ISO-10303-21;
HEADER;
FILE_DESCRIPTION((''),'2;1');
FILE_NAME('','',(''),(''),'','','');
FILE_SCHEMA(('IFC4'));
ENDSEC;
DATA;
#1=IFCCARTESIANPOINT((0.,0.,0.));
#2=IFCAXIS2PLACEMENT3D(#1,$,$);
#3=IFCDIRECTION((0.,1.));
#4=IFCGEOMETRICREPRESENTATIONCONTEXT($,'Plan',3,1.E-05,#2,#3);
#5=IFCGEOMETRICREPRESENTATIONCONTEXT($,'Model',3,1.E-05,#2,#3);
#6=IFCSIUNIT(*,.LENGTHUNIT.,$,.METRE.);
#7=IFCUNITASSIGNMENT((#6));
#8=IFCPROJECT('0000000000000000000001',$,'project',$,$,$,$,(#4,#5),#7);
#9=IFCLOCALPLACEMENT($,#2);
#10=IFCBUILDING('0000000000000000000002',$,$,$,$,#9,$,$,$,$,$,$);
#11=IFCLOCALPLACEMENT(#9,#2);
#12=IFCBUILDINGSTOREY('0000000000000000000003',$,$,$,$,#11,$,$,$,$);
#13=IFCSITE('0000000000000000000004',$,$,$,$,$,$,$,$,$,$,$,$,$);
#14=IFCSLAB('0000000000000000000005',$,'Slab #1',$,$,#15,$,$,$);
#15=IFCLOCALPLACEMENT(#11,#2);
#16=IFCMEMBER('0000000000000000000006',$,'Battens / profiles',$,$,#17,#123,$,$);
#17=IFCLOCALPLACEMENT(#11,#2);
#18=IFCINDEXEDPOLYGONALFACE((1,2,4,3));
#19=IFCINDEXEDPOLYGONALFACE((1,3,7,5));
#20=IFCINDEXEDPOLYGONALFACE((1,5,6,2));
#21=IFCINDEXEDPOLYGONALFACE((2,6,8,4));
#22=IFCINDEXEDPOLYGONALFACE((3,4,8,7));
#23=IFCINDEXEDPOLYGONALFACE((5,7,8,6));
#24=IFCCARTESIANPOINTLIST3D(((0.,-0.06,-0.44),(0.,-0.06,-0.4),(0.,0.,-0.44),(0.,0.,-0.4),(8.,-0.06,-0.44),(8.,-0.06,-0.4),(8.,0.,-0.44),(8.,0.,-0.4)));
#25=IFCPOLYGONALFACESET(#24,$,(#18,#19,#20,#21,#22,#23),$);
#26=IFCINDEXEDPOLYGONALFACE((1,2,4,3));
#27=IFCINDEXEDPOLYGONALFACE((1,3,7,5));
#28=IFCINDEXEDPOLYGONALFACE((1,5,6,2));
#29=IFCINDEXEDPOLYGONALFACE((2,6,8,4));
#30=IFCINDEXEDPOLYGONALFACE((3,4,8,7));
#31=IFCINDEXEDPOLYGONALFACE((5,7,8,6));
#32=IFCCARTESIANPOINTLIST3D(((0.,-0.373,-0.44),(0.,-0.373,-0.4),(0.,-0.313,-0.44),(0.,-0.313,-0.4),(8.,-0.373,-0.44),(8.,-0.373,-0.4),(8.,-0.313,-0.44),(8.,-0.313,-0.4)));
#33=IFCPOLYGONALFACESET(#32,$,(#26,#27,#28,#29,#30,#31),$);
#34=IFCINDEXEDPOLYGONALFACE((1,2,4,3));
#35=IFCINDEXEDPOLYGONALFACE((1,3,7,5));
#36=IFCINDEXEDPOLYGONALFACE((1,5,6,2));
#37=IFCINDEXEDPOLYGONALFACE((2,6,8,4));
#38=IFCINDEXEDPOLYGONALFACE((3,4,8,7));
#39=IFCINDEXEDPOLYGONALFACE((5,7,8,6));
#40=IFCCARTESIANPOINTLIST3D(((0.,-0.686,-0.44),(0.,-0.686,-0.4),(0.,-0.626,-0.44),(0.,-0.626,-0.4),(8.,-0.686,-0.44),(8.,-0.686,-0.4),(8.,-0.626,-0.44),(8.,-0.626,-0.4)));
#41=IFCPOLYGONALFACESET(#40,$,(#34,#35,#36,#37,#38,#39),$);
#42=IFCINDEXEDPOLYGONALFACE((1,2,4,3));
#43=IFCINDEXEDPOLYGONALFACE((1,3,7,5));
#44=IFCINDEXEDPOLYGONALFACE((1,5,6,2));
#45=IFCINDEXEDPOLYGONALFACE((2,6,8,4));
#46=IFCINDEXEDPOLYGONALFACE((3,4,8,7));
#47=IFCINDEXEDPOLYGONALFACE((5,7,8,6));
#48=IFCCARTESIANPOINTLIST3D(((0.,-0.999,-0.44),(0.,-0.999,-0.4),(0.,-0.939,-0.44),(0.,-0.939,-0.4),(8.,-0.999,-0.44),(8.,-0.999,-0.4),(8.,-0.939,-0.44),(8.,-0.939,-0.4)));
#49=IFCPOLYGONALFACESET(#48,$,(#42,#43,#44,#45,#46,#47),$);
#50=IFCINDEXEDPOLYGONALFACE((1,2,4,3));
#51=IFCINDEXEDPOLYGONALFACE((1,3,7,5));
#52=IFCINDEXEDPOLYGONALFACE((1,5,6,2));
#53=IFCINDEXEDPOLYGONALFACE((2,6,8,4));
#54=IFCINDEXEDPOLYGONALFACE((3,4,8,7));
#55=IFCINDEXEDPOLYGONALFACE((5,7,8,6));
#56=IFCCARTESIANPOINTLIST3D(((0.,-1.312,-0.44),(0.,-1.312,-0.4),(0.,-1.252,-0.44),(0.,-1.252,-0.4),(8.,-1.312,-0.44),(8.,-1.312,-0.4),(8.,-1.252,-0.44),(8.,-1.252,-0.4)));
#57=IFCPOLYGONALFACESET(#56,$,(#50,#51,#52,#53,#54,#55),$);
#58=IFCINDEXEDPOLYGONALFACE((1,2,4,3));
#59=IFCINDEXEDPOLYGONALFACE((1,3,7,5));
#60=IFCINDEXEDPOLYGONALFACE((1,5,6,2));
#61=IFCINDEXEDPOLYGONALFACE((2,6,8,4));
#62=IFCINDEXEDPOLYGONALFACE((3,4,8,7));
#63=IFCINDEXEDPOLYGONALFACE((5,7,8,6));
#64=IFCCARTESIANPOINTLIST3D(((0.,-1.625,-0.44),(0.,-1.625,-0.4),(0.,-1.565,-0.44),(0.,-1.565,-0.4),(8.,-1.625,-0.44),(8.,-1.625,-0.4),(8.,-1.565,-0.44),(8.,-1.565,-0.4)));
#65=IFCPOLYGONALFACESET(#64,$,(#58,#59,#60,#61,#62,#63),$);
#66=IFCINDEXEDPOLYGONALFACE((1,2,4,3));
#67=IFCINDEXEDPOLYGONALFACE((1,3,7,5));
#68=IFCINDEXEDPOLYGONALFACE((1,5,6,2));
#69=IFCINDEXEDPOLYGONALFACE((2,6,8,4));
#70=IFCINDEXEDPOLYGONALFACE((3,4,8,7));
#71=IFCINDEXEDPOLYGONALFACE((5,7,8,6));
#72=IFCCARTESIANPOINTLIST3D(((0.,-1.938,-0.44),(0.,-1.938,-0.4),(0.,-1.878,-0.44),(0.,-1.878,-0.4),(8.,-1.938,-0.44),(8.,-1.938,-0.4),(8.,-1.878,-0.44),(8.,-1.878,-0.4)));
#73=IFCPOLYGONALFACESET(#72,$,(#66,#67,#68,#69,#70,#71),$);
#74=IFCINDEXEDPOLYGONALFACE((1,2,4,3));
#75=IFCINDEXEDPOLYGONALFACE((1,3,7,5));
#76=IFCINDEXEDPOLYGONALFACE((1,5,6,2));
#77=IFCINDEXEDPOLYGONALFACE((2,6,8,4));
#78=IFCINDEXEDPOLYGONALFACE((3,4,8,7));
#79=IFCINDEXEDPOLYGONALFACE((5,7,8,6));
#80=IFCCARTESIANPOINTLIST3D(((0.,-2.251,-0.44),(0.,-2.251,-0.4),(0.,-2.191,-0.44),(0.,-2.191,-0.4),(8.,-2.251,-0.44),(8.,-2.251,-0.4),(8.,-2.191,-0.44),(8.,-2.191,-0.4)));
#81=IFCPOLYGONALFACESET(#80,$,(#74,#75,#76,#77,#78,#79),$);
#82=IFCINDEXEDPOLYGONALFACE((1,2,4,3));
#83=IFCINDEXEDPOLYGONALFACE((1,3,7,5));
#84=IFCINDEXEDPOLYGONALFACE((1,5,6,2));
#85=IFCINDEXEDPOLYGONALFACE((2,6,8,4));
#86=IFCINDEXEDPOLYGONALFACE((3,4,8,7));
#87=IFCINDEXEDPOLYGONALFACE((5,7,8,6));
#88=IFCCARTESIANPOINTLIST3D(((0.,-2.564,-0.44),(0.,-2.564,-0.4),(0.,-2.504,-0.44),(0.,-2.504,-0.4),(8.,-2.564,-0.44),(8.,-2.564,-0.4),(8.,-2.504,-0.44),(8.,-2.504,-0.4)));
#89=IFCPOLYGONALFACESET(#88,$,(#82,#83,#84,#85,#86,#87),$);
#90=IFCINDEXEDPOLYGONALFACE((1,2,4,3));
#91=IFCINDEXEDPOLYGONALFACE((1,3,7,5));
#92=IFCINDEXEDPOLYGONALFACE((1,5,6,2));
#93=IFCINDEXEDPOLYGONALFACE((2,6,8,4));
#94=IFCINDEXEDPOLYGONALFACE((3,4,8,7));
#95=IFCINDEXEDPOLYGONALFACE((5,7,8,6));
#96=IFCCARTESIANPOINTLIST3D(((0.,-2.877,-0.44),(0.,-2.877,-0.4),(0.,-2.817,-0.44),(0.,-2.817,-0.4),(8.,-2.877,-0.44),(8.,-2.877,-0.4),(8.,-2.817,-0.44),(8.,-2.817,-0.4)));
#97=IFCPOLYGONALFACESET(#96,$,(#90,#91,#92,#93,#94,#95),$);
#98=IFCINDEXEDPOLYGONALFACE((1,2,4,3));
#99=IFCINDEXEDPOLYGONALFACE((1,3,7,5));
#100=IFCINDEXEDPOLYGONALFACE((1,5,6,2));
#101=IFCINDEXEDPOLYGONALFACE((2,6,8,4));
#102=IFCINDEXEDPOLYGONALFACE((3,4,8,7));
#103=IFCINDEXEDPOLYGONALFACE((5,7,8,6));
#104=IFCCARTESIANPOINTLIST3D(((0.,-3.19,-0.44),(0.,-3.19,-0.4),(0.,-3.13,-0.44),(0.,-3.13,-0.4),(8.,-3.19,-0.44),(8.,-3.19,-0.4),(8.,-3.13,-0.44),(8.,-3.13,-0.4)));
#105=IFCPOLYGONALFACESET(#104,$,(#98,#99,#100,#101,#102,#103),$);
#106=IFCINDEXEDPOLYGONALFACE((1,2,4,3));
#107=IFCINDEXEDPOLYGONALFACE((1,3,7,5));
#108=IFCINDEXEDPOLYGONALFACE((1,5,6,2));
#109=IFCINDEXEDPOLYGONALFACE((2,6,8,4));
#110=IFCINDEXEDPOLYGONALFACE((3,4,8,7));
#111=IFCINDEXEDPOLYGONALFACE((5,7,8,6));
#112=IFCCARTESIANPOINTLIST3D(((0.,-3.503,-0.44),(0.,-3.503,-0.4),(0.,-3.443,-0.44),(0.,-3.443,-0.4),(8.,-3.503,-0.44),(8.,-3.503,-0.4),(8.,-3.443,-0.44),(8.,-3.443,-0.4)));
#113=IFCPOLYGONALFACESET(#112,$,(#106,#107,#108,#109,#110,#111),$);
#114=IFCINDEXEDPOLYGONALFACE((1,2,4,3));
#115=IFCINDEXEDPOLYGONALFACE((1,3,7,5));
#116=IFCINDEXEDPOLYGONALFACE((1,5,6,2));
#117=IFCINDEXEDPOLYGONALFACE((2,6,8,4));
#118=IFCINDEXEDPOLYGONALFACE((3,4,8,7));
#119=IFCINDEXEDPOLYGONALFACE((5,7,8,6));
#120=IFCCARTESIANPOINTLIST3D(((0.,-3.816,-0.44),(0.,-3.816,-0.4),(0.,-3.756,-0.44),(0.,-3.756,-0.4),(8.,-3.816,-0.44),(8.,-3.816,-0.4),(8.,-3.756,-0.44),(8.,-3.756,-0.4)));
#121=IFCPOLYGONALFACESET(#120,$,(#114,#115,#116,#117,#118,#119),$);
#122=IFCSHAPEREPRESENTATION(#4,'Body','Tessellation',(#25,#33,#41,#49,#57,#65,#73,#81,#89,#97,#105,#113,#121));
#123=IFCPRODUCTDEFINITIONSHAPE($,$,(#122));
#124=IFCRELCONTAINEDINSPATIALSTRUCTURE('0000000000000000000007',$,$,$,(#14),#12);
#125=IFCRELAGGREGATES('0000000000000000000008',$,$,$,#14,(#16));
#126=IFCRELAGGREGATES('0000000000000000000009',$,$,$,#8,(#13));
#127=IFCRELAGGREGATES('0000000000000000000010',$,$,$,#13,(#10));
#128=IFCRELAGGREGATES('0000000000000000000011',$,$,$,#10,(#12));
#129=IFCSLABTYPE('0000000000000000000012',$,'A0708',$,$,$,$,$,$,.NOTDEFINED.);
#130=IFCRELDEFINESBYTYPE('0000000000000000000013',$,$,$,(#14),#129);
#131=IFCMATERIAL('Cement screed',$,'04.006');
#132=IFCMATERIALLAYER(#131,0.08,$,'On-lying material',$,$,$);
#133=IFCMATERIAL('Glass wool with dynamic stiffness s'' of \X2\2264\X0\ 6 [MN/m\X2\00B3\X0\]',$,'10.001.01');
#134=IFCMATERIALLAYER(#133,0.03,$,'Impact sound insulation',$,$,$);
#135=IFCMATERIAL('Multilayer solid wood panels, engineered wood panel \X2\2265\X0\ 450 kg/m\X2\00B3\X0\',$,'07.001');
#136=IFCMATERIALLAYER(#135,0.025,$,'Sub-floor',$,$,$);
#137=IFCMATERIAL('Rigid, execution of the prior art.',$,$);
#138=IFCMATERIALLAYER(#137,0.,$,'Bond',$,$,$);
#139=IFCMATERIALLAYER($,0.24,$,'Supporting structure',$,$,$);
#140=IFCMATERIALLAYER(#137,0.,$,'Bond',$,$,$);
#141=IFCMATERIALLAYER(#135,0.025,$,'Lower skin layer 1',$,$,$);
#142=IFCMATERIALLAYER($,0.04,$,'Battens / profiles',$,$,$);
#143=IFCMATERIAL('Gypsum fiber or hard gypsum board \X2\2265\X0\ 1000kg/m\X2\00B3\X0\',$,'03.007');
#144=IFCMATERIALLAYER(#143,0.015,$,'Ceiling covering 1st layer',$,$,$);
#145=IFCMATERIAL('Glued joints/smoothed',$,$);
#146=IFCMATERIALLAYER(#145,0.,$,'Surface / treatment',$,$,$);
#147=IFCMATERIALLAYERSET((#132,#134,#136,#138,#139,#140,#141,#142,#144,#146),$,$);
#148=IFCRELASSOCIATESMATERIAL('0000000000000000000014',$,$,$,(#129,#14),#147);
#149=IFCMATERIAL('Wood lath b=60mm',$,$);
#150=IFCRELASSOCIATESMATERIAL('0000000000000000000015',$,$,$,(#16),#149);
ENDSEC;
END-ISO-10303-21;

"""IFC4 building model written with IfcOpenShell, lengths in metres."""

from ifc_helpers import new_model, si_unit, direction, frame, frame_2d, origin, place, context, project, spatial, rectangle, extrude, material, layer, layer_set, type_object, element, aggregate, save


model = new_model("IFC4")

# Units and contexts
plan_context = context("Plan", 3, precision=1e-05, world=origin(), true_north=direction((0.0, 1.0)))
model_context = context("Model", 3, precision=1e-05, world=origin(), true_north=direction((0.0, 1.0)))
ifc_project = project(units=[si_unit("LENGTHUNIT", "METRE")], contexts=[plan_context, model_context])

# Site, building, storey
site = spatial("IfcSite", under=ifc_project)
building_placement = place(None, origin())
building = spatial("IfcBuilding", under=site, at=building_placement)
storey_placement = place(building_placement, origin())
storey = spatial("IfcBuildingStorey", under=building, at=storey_placement)

# Slab, member
ifc_material_1 = material(Name="Cement screed", Category="04.006")
ifc_layer_1 = layer(ifc_material_1, 0.08, Name="On-lying material")
ifc_material_2 = material(Name="Glass wool with dynamic stiffness s' of ≤ 6 [MN/m³]", Category="10.001.01")
ifc_layer_2 = layer(ifc_material_2, 0.03, Name="Impact sound insulation")
ifc_material_3 = material(Name="Multilayer solid wood panels, engineered wood panel ≥ 450 kg/m³", Category="07.001")
ifc_layer_3 = layer(ifc_material_3, 0.025, Name="Sub-floor")
ifc_material_4 = material(Name="Rigid, execution of the prior art.")
ifc_layer_4 = layer(ifc_material_4, 0.0, Name="Bond")
ifc_layer_5 = layer(None, 0.24, Name="Supporting structure")
ifc_layer_6 = layer(ifc_material_4, 0.0, Name="Bond")
ifc_layer_7 = layer(ifc_material_3, 0.025, Name="Lower skin layer 1")
ifc_layer_8 = layer(None, 0.04, Name="Battens / profiles")
ifc_material_5 = material(Name="Gypsum fiber or hard gypsum board ≥ 1000kg/m³", Category="03.007")
ifc_layer_9 = layer(ifc_material_5, 0.015, Name="Ceiling covering 1st layer")
ifc_material_6 = material(Name="Glued joints/smoothed")
ifc_layer_10 = layer(ifc_material_6, 0.0, Name="Surface / treatment")
ifc_layer_set = layer_set([ifc_layer_1, ifc_layer_2, ifc_layer_3, ifc_layer_4, ifc_layer_5, ifc_layer_6, ifc_layer_7, ifc_layer_8, ifc_layer_9, ifc_layer_10])
slab_type = type_object("IfcSlabType", Name="A0708", PredefinedType="NOTDEFINED", material=ifc_layer_set)
slab_placement = place(None, frame((0.0, 0.0, 0.0), z_axis=(0.0, 0.0, -1.0), x_axis=(1.0, 0.0, 0.0)))
slab = element("IfcSlab", 1, at=slab_placement, inside=storey, type_object=slab_type, material=ifc_layer_set, Name="Slab #1")
ifc_material_7 = material(Name="Wood lath b=60mm")
member_1_placement = place(slab_placement, origin())
member_1 = element("IfcMember", 2, at=member_1_placement, material=ifc_material_7, Name="Battens / profiles", context=plan_context, shape_type="SweptSolid", body=[
    extrude(rectangle(XDim=0.06, YDim=0.04, at=frame_2d((0.03, 0.02), x_axis=(1.0, 0.0))), frame((0.0, 0.0, 0.4), z_axis=(1.0, 0.0, 0.0), x_axis=(0.0, 1.0, 0.0)), (0.0, 0.0, 1.0), 8.0),
    extrude(rectangle(XDim=0.06, YDim=0.04, at=frame_2d((0.03, 0.02), x_axis=(1.0, 0.0))), frame((0.0, 0.313, 0.4), z_axis=(1.0, 0.0, 0.0), x_axis=(0.0, 1.0, 0.0)), (0.0, 0.0, 1.0), 8.0),
    extrude(rectangle(XDim=0.06, YDim=0.04, at=frame_2d((0.03, 0.02), x_axis=(1.0, 0.0))), frame((0.0, 0.626, 0.4), z_axis=(1.0, 0.0, 0.0), x_axis=(0.0, 1.0, 0.0)), (0.0, 0.0, 1.0), 8.0),
    extrude(rectangle(XDim=0.06, YDim=0.04, at=frame_2d((0.03, 0.02), x_axis=(1.0, 0.0))), frame((0.0, 0.939, 0.4), z_axis=(1.0, 0.0, 0.0), x_axis=(0.0, 1.0, 0.0)), (0.0, 0.0, 1.0), 8.0),
    extrude(rectangle(XDim=0.06, YDim=0.04, at=frame_2d((0.03, 0.02), x_axis=(1.0, 0.0))), frame((0.0, 1.252, 0.4), z_axis=(1.0, 0.0, 0.0), x_axis=(0.0, 1.0, 0.0)), (0.0, 0.0, 1.0), 8.0),
    extrude(rectangle(XDim=0.06, YDim=0.04, at=frame_2d((0.03, 0.02), x_axis=(1.0, 0.0))), frame((0.0, 1.565, 0.4), z_axis=(1.0, 0.0, 0.0), x_axis=(0.0, 1.0, 0.0)), (0.0, 0.0, 1.0), 8.0),
    extrude(rectangle(XDim=0.06, YDim=0.04, at=frame_2d((0.03, 0.02), x_axis=(1.0, 0.0))), frame((0.0, 1.878, 0.4), z_axis=(1.0, 0.0, 0.0), x_axis=(0.0, 1.0, 0.0)), (0.0, 0.0, 1.0), 8.0),
    extrude(rectangle(XDim=0.06, YDim=0.04, at=frame_2d((0.03, 0.02), x_axis=(1.0, 0.0))), frame((0.0, 2.191, 0.4), z_axis=(1.0, 0.0, 0.0), x_axis=(0.0, 1.0, 0.0)), (0.0, 0.0, 1.0), 8.0),
    extrude(rectangle(XDim=0.06, YDim=0.04, at=frame_2d((0.03, 0.02), x_axis=(1.0, 0.0))), frame((0.0, 2.504, 0.4), z_axis=(1.0, 0.0, 0.0), x_axis=(0.0, 1.0, 0.0)), (0.0, 0.0, 1.0), 8.0),
    extrude(rectangle(XDim=0.06, YDim=0.04, at=frame_2d((0.03, 0.02), x_axis=(1.0, 0.0))), frame((0.0, 2.817, 0.4), z_axis=(1.0, 0.0, 0.0), x_axis=(0.0, 1.0, 0.0)), (0.0, 0.0, 1.0), 8.0),
    extrude(rectangle(XDim=0.06, YDim=0.04, at=frame_2d((0.03, 0.02), x_axis=(1.0, 0.0))), frame((0.0, 3.13, 0.4), z_axis=(1.0, 0.0, 0.0), x_axis=(0.0, 1.0, 0.0)), (0.0, 0.0, 1.0), 8.0),
    extrude(rectangle(XDim=0.06, YDim=0.04, at=frame_2d((0.03, 0.02), x_axis=(1.0, 0.0))), frame((0.0, 3.443, 0.4), z_axis=(1.0, 0.0, 0.0), x_axis=(0.0, 1.0, 0.0)), (0.0, 0.0, 1.0), 8.0),
    extrude(rectangle(XDim=0.06, YDim=0.04, at=frame_2d((0.03, 0.02), x_axis=(1.0, 0.0))), frame((0.0, 3.756, 0.4), z_axis=(1.0, 0.0, 0.0), x_axis=(0.0, 1.0, 0.0)), (0.0, 0.0, 1.0), 8.0),
])
aggregate(slab, [member_1])

save(model, "model.ifc")
